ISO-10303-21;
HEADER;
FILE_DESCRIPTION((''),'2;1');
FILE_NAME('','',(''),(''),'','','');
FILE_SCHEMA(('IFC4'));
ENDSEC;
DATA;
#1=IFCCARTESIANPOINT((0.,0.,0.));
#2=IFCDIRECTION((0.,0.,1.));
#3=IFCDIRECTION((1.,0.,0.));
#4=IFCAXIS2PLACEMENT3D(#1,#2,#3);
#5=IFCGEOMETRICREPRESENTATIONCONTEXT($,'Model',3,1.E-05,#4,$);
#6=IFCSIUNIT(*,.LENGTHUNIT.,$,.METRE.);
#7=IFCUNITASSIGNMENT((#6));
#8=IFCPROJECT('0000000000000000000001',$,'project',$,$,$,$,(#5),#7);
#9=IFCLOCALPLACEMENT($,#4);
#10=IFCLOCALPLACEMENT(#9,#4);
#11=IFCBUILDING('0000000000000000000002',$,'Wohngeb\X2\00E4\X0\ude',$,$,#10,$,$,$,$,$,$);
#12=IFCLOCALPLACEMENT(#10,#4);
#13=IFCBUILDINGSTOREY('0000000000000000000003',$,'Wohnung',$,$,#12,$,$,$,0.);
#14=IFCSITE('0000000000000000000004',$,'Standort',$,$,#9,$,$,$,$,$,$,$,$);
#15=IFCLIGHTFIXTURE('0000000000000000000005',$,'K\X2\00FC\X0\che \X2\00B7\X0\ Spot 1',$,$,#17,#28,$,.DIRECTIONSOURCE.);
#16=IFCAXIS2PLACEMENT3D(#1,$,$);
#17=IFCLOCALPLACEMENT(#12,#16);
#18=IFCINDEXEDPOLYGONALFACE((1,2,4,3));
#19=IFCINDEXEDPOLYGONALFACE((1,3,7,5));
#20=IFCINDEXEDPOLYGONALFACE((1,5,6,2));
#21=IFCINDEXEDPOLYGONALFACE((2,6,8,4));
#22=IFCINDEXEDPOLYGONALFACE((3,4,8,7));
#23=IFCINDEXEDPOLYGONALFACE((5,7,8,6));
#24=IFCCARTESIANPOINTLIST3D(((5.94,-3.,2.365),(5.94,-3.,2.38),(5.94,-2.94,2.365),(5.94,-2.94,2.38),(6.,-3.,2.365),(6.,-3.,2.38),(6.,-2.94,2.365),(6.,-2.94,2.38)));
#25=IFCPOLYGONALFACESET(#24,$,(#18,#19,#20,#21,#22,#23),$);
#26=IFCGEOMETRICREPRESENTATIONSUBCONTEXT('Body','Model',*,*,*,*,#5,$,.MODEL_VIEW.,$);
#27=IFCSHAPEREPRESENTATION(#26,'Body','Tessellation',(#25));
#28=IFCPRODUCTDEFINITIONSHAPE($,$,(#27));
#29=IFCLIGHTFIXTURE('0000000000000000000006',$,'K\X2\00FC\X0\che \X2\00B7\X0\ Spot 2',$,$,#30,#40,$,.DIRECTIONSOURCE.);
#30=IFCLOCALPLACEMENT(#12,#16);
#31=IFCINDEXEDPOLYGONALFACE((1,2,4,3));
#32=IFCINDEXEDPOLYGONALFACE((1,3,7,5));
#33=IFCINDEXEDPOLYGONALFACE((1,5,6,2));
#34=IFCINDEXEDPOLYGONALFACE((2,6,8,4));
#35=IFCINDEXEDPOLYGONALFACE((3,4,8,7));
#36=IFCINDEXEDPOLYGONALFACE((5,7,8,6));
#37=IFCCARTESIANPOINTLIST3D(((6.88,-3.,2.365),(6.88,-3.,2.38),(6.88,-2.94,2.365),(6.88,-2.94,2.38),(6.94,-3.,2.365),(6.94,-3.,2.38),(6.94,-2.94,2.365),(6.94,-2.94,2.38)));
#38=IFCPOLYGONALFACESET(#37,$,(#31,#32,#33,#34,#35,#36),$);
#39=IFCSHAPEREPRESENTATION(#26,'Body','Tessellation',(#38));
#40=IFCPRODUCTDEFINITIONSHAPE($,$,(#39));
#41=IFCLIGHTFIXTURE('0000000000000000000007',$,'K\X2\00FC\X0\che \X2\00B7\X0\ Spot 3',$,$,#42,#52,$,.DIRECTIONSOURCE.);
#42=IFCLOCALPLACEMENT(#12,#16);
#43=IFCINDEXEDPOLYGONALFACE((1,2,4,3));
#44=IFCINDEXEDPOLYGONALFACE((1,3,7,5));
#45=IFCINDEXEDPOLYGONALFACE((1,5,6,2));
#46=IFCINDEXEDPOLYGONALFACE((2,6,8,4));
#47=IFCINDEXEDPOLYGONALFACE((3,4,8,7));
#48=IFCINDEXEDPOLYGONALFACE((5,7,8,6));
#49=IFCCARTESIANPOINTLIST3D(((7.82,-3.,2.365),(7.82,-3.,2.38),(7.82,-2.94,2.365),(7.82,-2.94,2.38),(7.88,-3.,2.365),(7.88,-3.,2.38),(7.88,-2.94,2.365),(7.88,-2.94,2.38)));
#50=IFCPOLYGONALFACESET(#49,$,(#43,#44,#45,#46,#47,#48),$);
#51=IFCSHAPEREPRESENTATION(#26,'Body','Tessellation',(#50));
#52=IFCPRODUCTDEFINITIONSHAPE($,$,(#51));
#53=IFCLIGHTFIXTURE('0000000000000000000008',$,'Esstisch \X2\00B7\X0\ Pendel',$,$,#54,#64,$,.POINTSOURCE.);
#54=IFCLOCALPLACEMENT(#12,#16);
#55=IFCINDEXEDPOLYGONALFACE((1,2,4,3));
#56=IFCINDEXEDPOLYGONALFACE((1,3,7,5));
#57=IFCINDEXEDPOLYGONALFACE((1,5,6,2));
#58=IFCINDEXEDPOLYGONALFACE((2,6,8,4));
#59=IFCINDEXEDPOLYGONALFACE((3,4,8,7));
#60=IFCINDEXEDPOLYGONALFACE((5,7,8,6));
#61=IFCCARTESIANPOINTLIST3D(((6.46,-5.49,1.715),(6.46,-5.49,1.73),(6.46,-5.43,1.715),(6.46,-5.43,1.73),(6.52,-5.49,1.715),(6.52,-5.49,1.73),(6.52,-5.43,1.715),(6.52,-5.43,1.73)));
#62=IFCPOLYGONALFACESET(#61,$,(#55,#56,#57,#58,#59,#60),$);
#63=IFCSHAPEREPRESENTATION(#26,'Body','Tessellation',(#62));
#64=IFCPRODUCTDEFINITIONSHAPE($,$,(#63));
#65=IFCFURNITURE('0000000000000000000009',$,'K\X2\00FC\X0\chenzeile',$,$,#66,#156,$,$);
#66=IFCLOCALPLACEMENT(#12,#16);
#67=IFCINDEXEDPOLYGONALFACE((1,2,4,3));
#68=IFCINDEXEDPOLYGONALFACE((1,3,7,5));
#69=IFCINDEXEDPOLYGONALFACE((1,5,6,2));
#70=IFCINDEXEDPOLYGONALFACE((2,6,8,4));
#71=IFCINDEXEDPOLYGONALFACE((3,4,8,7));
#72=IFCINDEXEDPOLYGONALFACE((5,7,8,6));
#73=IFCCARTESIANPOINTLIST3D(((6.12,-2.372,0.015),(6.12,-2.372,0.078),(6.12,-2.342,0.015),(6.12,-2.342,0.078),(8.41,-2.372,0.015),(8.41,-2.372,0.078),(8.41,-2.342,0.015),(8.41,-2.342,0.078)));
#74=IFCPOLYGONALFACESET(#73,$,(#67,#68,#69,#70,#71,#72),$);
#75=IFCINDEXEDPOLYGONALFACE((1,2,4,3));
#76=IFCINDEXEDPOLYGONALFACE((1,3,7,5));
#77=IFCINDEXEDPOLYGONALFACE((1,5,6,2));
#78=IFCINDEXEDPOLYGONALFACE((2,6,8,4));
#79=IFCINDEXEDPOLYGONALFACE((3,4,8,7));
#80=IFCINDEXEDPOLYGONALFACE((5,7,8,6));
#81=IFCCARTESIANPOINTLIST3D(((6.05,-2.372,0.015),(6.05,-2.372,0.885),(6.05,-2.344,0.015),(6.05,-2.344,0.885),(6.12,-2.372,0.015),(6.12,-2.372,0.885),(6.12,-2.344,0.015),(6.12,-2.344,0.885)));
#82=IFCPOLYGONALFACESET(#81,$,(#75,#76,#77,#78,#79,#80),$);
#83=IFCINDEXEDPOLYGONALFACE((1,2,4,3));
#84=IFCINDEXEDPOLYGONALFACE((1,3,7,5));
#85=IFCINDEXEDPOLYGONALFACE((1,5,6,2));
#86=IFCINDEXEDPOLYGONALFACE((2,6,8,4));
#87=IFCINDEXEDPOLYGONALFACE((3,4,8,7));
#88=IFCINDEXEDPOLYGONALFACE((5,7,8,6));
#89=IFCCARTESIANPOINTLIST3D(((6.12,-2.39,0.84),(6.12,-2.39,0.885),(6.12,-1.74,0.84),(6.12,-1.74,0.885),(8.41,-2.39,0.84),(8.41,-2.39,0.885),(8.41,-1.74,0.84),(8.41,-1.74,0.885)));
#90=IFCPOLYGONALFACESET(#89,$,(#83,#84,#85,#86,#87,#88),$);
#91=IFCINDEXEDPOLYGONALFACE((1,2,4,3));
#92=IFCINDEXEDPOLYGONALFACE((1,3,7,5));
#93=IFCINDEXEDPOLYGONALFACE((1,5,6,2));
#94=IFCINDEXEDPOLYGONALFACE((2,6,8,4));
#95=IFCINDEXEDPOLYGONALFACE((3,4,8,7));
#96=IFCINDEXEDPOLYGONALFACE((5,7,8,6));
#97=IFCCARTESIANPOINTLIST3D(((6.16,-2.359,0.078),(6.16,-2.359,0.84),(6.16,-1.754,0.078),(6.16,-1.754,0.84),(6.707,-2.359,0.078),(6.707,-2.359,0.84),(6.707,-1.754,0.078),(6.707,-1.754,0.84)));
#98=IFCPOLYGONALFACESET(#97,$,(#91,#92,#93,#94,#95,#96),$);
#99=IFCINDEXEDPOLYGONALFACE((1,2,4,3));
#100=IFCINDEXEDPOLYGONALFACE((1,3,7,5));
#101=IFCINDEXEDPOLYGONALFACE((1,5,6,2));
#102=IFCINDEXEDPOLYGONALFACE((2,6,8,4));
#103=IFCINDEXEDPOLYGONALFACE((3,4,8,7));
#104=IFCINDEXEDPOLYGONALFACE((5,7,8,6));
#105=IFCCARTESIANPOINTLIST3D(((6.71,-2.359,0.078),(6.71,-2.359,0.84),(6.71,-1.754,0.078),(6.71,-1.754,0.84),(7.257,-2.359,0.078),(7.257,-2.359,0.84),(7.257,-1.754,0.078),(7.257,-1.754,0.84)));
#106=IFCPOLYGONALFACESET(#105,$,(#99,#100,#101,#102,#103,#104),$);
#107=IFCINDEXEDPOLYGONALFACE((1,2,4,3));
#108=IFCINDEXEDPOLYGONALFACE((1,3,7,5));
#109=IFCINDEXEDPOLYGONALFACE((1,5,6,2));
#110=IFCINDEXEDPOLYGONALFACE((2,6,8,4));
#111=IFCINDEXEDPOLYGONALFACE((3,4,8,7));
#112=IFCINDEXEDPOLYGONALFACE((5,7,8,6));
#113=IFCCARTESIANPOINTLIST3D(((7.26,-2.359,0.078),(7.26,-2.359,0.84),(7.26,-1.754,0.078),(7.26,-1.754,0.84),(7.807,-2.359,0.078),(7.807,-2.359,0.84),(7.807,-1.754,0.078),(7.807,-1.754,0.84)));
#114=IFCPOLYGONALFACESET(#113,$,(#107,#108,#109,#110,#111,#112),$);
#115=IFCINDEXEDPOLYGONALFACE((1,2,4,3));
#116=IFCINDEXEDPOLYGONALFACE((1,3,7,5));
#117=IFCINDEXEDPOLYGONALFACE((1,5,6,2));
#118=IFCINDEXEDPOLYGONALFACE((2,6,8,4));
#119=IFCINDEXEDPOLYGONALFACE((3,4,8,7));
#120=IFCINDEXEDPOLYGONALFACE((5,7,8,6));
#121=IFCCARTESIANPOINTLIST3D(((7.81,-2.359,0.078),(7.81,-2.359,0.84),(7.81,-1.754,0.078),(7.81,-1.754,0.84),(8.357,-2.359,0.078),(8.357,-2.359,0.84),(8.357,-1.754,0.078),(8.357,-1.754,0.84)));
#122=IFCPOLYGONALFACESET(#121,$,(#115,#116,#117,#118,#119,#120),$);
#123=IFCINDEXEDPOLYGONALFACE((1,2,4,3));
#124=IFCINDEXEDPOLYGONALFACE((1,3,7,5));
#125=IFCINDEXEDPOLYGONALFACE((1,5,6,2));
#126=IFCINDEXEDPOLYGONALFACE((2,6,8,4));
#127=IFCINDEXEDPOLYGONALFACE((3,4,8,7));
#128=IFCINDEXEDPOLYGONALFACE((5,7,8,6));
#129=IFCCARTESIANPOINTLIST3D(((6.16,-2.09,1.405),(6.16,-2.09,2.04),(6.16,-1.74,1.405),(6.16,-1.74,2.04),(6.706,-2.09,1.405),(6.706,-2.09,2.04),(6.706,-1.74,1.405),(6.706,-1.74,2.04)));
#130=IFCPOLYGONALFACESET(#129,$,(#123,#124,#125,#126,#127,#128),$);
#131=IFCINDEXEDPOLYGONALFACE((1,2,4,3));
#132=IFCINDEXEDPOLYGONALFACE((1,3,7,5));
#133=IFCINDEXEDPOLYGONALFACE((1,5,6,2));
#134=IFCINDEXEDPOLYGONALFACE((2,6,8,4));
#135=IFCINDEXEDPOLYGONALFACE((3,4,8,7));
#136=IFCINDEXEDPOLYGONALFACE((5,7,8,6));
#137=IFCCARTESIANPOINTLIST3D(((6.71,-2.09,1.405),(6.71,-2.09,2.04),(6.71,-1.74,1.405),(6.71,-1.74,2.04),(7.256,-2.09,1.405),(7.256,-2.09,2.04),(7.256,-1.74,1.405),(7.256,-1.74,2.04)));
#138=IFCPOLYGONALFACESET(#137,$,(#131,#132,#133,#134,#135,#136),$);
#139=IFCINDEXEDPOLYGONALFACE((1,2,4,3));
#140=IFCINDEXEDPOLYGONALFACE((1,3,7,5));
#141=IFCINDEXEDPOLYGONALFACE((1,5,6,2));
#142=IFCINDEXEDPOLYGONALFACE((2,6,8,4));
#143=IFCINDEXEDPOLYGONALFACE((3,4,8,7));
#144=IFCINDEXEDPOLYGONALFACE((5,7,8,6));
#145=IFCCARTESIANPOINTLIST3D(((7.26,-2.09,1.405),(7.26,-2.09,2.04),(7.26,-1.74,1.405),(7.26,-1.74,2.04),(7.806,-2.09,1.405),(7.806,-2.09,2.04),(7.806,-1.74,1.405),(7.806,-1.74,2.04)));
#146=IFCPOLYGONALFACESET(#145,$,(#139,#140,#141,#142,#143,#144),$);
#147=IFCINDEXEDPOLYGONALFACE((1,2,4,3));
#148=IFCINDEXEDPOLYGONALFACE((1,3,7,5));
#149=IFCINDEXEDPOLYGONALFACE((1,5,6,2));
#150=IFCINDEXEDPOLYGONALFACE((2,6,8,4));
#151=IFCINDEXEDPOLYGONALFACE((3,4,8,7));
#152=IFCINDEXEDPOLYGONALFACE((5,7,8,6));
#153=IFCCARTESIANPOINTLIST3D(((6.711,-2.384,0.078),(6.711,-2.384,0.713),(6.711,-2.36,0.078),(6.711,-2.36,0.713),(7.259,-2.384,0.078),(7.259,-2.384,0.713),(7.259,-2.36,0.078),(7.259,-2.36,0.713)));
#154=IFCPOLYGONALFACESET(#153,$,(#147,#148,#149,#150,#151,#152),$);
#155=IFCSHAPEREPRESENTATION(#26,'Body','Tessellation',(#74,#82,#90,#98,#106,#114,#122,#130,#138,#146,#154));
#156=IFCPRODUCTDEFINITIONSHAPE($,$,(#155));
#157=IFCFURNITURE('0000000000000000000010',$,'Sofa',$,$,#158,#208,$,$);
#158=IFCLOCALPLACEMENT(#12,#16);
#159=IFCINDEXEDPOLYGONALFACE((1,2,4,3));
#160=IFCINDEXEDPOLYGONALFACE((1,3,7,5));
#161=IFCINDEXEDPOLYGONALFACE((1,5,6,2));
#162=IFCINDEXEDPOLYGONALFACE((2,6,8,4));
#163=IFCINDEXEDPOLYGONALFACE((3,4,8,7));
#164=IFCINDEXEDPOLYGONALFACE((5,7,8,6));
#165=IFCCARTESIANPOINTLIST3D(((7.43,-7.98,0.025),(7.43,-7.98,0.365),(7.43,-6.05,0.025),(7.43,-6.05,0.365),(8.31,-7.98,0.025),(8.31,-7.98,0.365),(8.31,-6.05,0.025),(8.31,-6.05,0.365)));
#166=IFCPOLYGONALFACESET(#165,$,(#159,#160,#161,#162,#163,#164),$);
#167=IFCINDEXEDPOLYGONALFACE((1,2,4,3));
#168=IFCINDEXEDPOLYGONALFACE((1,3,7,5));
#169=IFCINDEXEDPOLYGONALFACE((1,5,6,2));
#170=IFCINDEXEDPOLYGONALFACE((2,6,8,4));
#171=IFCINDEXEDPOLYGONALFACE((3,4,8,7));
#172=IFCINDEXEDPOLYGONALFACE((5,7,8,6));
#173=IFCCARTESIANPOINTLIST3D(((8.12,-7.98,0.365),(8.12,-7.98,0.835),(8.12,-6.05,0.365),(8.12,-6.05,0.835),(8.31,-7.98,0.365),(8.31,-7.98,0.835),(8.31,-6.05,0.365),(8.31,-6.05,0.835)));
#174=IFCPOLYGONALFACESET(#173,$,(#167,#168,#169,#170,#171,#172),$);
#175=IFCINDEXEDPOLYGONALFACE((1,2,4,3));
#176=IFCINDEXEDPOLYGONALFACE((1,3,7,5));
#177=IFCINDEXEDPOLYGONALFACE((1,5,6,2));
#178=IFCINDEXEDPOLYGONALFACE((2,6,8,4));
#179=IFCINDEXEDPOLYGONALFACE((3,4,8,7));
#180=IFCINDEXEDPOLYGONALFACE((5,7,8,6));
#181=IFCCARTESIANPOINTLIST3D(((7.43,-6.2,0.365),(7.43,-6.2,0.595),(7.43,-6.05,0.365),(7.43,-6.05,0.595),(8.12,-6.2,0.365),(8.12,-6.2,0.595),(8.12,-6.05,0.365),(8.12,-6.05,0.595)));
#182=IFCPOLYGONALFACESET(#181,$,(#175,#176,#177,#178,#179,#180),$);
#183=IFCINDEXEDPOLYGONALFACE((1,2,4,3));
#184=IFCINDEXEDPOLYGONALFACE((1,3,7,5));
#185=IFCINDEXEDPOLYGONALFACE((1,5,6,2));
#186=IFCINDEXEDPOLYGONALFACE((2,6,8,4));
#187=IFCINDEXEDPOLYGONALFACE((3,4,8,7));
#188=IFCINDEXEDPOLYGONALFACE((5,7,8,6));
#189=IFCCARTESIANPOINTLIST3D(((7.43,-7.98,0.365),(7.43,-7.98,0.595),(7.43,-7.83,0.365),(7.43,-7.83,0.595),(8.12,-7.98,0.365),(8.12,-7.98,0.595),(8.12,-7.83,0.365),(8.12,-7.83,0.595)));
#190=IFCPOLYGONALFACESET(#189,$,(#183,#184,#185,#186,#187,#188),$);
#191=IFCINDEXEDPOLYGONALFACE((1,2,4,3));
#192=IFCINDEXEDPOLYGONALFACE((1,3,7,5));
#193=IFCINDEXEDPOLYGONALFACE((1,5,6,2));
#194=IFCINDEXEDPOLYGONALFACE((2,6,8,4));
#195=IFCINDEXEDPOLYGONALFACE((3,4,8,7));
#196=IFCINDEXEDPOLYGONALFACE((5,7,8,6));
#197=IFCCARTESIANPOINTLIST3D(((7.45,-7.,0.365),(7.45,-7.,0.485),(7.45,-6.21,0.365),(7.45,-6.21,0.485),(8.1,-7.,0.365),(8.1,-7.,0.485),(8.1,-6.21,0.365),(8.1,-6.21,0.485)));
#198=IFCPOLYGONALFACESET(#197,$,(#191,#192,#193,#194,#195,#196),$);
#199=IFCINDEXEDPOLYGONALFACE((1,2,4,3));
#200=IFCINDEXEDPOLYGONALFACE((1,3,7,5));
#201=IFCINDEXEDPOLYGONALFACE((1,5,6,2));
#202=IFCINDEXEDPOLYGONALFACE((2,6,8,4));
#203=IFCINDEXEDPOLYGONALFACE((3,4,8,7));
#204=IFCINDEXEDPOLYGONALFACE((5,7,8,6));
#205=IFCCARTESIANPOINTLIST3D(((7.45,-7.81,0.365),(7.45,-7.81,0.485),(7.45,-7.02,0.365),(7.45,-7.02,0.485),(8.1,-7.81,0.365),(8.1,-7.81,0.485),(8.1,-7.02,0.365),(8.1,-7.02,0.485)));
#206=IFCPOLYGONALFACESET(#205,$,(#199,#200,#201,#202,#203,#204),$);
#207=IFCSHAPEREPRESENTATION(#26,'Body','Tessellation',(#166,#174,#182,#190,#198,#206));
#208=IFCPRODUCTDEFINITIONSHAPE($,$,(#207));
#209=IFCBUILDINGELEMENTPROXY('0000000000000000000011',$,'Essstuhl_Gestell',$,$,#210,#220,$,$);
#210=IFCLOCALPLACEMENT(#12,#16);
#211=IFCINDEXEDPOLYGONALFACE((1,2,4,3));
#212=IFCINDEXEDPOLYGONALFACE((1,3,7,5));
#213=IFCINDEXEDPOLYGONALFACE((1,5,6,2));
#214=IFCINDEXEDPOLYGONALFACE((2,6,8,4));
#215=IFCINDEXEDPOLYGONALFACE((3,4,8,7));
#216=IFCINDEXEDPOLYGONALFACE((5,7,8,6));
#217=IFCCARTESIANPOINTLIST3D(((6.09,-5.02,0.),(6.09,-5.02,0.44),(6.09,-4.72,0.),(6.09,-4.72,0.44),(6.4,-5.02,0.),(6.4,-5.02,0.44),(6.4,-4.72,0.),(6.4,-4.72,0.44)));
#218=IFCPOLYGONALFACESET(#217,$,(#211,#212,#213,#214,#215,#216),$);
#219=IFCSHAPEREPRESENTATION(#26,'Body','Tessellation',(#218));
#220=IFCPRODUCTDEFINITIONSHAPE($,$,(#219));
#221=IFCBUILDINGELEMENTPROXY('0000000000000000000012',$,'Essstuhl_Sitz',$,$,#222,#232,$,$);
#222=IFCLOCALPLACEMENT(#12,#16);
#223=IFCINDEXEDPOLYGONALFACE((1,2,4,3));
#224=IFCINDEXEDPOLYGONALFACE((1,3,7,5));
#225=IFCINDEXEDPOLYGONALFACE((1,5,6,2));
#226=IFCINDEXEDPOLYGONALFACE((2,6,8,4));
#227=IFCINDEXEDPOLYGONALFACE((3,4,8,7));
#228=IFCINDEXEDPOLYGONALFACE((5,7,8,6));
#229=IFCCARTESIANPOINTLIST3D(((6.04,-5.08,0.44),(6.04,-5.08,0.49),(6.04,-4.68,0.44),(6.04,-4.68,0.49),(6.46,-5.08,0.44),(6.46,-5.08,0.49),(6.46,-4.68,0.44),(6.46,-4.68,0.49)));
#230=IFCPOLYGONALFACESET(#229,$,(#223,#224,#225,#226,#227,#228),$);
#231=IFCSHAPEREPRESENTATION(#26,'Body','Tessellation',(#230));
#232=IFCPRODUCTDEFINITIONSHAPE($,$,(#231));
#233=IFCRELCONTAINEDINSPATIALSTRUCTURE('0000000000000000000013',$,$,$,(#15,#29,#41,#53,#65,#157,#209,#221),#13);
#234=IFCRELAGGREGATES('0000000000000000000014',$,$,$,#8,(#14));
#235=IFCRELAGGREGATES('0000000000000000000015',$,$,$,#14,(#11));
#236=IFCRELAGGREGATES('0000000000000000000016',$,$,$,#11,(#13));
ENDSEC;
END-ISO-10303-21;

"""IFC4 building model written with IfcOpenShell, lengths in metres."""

from ifc_helpers import new_model, si_unit, frame, origin, origin_with_axes, place, context, subcontext, project, spatial, polyline, outline, extrude, element, save


model = new_model("IFC4")

# Units and contexts
model_context = context("Model", 3, precision=1e-05, world=origin_with_axes())
body_context = subcontext(model_context, "Body", "Model", "MODEL_VIEW")
ifc_project = project(units=[si_unit("LENGTHUNIT", "METRE")], contexts=[model_context])

# Site, building, storey
site_placement = place(None, origin_with_axes())
site = spatial("IfcSite", under=ifc_project, at=site_placement, Name="Standort")
building_placement = place(site_placement, origin_with_axes())
building = spatial("IfcBuilding", under=site, at=building_placement, Name="Wohngebäude")
storey_placement = place(building_placement, origin_with_axes())
storey = spatial("IfcBuildingStorey", under=building, at=storey_placement, Name="Wohnung", Elevation=0.0)

# Light fixtures
for number, where, z_axis, x_axis, name in (
    (1, (5.94, -2.94, 2.365), (0.0, 0.0, 1.0), (1.0, 0.0, 0.0), "Küche · Spot 1"),
    (2, (6.88, -2.94, 2.365), (0.0, 0.0, 1.0), (1.0, 0.0, 0.0), "Küche · Spot 2"),
    (3, (7.82, -2.94, 2.365), (0.0, 0.0, 1.0), (1.0, 0.0, 0.0), "Küche · Spot 3"),
):
    element("IfcLightFixture", number, at=place(storey_placement, frame(where, z_axis=z_axis, x_axis=x_axis)), inside=storey, Name=name, PredefinedType="DIRECTIONSOURCE", context=body_context, shape_type="SweptSolid", body=[
        extrude(outline(polyline([(0.0, 0.0), (0.0, -0.06), (0.06, -0.06), (0.06, 0.0), (0.0, 0.0)])), origin(), (0.0, 0.0, 1.0), 0.015),
    ])
light_fixture_placement = place(storey_placement, frame((6.46, -5.43, 1.715), z_axis=(0.0, 0.0, 1.0), x_axis=(1.0, 0.0, 0.0)))
element("IfcLightFixture", 4, at=light_fixture_placement, inside=storey, Name="Esstisch · Pendel", PredefinedType="POINTSOURCE", context=body_context, shape_type="SweptSolid", body=[
    extrude(outline(polyline([(0.0, 0.0), (0.0, -0.06), (0.06, -0.06), (0.06, 0.0), (0.0, 0.0)])), origin(), (0.0, 0.0, 1.0), 0.015),
])

# Furniture
furniture_1_placement = place(storey_placement, frame((6.05, -1.74, 0.015), z_axis=(0.0, 0.0, 1.0), x_axis=(1.0, 0.0, 0.0)))
element("IfcFurniture", 5, at=furniture_1_placement, inside=storey, Name="Küchenzeile", context=body_context, shape_type="SweptSolid", body=[
    extrude(outline(polyline([(0.07, -0.602), (0.07, -0.632), (2.36, -0.632), (2.36, -0.602), (0.07, -0.602)])), origin(), (0.0, 0.0, 1.0), 0.063),
    extrude(outline(polyline([(0.0, -0.604), (0.0, -0.632), (0.07, -0.632), (0.07, -0.604), (0.0, -0.604)])), origin(), (0.0, 0.0, 1.0), 0.87),
    extrude(outline(polyline([(0.07, 0.0), (0.07, -0.65), (2.36, -0.65), (2.36, 0.0), (0.07, 0.0)])), frame((0.0, 0.0, 0.825)), (0.0, 0.0, 1.0), 0.045),
    extrude(outline(polyline([(0.11, -0.014), (0.11, -0.619), (0.657, -0.619), (0.657, -0.014), (0.11, -0.014)])), frame((0.0, 0.0, 0.063)), (0.0, 0.0, 1.0), 0.762),
    extrude(outline(polyline([(0.66, -0.014), (0.66, -0.619), (1.207, -0.619), (1.207, -0.014), (0.66, -0.014)])), frame((0.0, 0.0, 0.063)), (0.0, 0.0, 1.0), 0.762),
    extrude(outline(polyline([(1.21, -0.014), (1.21, -0.619), (1.757, -0.619), (1.757, -0.014), (1.21, -0.014)])), frame((0.0, 0.0, 0.063)), (0.0, 0.0, 1.0), 0.762),
    extrude(outline(polyline([(1.76, -0.014), (1.76, -0.619), (2.307, -0.619), (2.307, -0.014), (1.76, -0.014)])), frame((0.0, 0.0, 0.063)), (0.0, 0.0, 1.0), 0.762),
    extrude(outline(polyline([(0.11, 0.0), (0.11, -0.35), (0.656, -0.35), (0.656, 0.0), (0.11, 0.0)])), frame((0.0, 0.0, 1.39)), (0.0, 0.0, 1.0), 0.635),
    extrude(outline(polyline([(0.66, 0.0), (0.66, -0.35), (1.206, -0.35), (1.206, 0.0), (0.66, 0.0)])), frame((0.0, 0.0, 1.39)), (0.0, 0.0, 1.0), 0.635),
    extrude(outline(polyline([(1.21, 0.0), (1.21, -0.35), (1.756, -0.35), (1.756, 0.0), (1.21, 0.0)])), frame((0.0, 0.0, 1.39)), (0.0, 0.0, 1.0), 0.635),
    extrude(outline(polyline([(0.661, -0.62), (0.661, -0.644), (1.209, -0.644), (1.209, -0.62), (0.661, -0.62)])), frame((0.0, 0.0, 0.063)), (0.0, 0.0, 1.0), 0.635),
])
furniture_2_placement = place(storey_placement, frame((7.43, -6.05, 0.025), z_axis=(0.0, 0.0, 1.0), x_axis=(1.0, 0.0, 0.0)))
element("IfcFurniture", 6, at=furniture_2_placement, inside=storey, Name="Sofa", context=body_context, shape_type="SweptSolid", body=[
    extrude(outline(polyline([(0.0, 0.0), (0.0, -1.93), (0.88, -1.93), (0.88, 0.0), (0.0, 0.0)])), origin(), (0.0, 0.0, 1.0), 0.34),
    extrude(outline(polyline([(0.69, 0.0), (0.69, -1.93), (0.88, -1.93), (0.88, 0.0), (0.69, 0.0)])), frame((0.0, 0.0, 0.34)), (0.0, 0.0, 1.0), 0.47),
    extrude(outline(polyline([(0.0, 0.0), (0.0, -0.15), (0.69, -0.15), (0.69, 0.0), (0.0, 0.0)])), frame((0.0, 0.0, 0.34)), (0.0, 0.0, 1.0), 0.23),
    extrude(outline(polyline([(0.0, -1.78), (0.0, -1.93), (0.69, -1.93), (0.69, -1.78), (0.0, -1.78)])), frame((0.0, 0.0, 0.34)), (0.0, 0.0, 1.0), 0.23),
    extrude(outline(polyline([(0.02, -0.16), (0.02, -0.95), (0.67, -0.95), (0.67, -0.16), (0.02, -0.16)])), frame((0.0, 0.0, 0.34)), (0.0, 0.0, 1.0), 0.12),
    extrude(outline(polyline([(0.02, -0.97), (0.02, -1.76), (0.67, -1.76), (0.67, -0.97), (0.02, -0.97)])), frame((0.0, 0.0, 0.34)), (0.0, 0.0, 1.0), 0.12),
])

# Building element proxies
proxy_1_placement = place(storey_placement, frame((6.09, -4.72, 0.0), z_axis=(0.0, 0.0, 1.0), x_axis=(1.0, 0.0, 0.0)))
element("IfcBuildingElementProxy", 7, at=proxy_1_placement, inside=storey, Name="Essstuhl_Gestell", context=body_context, shape_type="SweptSolid", body=[
    extrude(outline(polyline([(0.0, 0.0), (0.0, -0.3), (0.31, -0.3), (0.31, 0.0), (0.0, 0.0)])), origin(), (0.0, 0.0, 1.0), 0.44),
])
proxy_2_placement = place(storey_placement, frame((6.04, -4.68, 0.44), z_axis=(0.0, 0.0, 1.0), x_axis=(1.0, 0.0, 0.0)))
element("IfcBuildingElementProxy", 8, at=proxy_2_placement, inside=storey, Name="Essstuhl_Sitz", context=body_context, shape_type="SweptSolid", body=[
    extrude(outline(polyline([(0.0, 0.0), (0.0, -0.4), (0.42, -0.4), (0.42, 0.0), (0.0, 0.0)])), origin(), (0.0, 0.0, 1.0), 0.05),
])

save(model, "model.ifc")
